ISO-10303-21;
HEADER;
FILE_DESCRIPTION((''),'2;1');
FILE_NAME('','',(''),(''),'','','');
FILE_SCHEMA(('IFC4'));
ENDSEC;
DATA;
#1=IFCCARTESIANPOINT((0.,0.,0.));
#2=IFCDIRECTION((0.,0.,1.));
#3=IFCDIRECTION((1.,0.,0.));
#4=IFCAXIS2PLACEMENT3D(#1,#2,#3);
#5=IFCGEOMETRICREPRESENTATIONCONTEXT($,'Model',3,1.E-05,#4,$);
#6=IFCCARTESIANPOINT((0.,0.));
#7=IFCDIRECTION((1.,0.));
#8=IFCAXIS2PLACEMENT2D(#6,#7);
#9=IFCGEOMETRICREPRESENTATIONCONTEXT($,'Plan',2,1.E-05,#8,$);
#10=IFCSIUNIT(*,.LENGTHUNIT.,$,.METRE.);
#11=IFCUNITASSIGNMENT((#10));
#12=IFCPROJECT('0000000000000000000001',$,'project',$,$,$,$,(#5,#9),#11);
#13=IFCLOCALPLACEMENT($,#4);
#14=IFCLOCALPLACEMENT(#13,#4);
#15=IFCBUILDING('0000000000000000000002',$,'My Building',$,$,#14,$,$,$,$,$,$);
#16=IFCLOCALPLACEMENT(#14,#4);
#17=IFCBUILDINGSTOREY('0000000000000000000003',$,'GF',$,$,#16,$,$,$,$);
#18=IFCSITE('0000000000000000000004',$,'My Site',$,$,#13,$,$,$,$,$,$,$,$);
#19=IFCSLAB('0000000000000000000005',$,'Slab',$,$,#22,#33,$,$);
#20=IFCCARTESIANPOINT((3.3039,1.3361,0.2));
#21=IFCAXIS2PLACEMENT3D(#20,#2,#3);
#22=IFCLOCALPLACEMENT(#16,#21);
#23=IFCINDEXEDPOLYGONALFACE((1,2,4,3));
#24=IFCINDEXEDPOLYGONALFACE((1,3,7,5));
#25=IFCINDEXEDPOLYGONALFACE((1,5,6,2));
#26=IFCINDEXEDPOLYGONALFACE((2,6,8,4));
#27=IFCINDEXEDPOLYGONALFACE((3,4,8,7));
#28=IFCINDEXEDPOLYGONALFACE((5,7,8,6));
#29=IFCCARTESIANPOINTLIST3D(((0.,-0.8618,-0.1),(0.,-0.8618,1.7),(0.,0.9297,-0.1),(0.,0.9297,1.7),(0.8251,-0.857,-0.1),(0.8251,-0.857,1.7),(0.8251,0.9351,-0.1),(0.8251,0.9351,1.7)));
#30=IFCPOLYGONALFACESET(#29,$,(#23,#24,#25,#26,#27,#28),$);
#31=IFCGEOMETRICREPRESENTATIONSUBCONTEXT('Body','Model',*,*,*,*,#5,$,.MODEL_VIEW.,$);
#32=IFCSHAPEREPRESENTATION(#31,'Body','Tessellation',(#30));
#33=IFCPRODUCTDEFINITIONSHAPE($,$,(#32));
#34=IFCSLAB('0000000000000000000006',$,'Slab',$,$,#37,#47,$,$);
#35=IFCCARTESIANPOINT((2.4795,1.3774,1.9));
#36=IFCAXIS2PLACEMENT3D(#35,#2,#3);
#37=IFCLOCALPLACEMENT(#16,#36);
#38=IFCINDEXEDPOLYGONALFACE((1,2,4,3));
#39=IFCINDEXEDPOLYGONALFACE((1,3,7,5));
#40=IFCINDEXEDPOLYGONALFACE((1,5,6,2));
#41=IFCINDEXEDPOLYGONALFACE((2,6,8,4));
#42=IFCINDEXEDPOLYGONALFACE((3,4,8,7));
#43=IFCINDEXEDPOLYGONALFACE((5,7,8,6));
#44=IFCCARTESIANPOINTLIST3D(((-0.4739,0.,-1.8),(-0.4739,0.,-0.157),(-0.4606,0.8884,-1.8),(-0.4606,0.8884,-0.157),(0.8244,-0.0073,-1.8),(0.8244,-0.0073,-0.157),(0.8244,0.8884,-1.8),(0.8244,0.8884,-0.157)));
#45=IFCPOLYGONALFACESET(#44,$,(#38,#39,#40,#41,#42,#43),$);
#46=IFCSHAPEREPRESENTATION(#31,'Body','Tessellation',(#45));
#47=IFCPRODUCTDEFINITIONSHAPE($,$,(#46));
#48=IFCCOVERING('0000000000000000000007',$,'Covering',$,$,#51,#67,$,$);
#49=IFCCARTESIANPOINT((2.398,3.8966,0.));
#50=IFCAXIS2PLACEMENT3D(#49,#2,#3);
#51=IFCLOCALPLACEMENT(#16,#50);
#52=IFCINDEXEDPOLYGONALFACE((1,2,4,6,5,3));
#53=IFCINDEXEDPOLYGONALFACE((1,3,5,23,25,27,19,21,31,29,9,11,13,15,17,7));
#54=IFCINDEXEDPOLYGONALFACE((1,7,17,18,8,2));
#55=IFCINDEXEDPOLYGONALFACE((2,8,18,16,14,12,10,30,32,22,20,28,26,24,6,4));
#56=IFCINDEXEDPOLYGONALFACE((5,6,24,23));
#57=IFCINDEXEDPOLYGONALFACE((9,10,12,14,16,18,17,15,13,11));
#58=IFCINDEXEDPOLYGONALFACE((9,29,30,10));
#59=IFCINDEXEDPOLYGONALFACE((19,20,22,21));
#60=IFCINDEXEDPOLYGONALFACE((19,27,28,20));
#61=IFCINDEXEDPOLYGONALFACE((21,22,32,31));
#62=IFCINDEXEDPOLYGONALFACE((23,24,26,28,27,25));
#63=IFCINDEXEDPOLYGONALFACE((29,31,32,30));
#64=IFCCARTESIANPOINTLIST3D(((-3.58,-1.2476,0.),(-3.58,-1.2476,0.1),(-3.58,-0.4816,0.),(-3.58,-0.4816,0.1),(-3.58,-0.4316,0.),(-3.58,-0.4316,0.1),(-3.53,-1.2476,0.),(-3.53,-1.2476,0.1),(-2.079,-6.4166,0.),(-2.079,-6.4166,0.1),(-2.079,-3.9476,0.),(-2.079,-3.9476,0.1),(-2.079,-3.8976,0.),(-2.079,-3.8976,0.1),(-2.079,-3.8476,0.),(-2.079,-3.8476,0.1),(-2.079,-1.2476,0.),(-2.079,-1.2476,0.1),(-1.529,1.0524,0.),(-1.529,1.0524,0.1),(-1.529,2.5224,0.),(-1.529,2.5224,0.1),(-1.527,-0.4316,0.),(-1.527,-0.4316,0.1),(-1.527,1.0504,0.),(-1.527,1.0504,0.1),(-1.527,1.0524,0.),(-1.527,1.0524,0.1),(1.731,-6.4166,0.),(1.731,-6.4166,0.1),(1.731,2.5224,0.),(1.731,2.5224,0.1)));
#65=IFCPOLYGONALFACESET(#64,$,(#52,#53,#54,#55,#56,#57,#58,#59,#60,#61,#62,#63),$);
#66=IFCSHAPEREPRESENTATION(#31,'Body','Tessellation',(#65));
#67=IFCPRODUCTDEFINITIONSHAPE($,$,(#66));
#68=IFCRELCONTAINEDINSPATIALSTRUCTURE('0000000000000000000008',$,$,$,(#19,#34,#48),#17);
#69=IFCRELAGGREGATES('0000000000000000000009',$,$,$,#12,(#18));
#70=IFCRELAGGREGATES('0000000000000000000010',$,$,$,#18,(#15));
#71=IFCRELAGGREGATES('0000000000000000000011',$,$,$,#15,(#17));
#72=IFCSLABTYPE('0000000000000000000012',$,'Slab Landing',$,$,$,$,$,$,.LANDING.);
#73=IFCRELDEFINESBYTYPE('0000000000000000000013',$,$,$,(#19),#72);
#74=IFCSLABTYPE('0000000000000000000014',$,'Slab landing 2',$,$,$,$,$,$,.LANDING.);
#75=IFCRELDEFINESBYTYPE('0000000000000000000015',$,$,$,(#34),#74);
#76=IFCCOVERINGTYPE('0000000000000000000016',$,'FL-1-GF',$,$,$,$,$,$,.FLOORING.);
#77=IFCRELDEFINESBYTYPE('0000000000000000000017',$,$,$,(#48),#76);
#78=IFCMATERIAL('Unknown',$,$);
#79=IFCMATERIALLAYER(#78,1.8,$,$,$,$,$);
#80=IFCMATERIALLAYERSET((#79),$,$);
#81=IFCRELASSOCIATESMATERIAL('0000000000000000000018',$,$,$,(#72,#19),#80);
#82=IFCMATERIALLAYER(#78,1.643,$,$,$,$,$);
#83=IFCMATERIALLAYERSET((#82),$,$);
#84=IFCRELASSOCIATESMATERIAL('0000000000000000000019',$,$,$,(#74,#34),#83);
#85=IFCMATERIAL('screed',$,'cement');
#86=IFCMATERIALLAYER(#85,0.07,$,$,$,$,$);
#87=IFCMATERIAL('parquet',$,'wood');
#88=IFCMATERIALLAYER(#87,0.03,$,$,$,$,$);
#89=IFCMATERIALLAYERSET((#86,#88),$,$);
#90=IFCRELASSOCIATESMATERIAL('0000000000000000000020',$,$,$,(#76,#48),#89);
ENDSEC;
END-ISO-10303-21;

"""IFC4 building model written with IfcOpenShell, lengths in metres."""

from ifc_helpers import new_model, si_unit, frame, origin_with_axes, origin_2d_with_axis, place, context, subcontext, project, spatial, line, indexed_curve, outline, extrude, material, layer, layer_set, layer_usage, type_object, element, save


model = new_model("IFC4")

# Units and contexts
model_context = context("Model", 3, precision=1e-05, world=origin_with_axes())
plan_context = context("Plan", 2, precision=1e-05, world=origin_2d_with_axis())
body_context_1 = subcontext(model_context, "Body", "Model", "MODEL_VIEW")
ifc_project = project(units=[si_unit("LENGTHUNIT", "METRE")], contexts=[model_context, plan_context])

# Site, building, storey
site_placement = place(None, origin_with_axes())
site = spatial("IfcSite", under=ifc_project, at=site_placement, Name="My Site")
building_placement = place(site_placement, origin_with_axes())
building = spatial("IfcBuilding", under=site, at=building_placement, Name="My Building")
storey_placement = place(building_placement, origin_with_axes())
storey = spatial("IfcBuildingStorey", under=building, at=storey_placement, Name="GF")

# Slabs
ifc_material_1 = material(Name="Unknown")
ifc_layer_1 = layer(ifc_material_1, 1.8)
ifc_layer_set_1 = layer_set([ifc_layer_1])
ifc_layer_usage_1 = layer_usage(ifc_layer_set_1, "AXIS3", "POSITIVE", -0.1)
slab_type_1 = type_object("IfcSlabType", Name="Slab Landing", PredefinedType="LANDING", material=ifc_layer_set_1)
slab_1_placement = place(storey_placement, frame((3.3039, 1.3361, 0.2), z_axis=(0.0, 0.0, 1.0), x_axis=(1.0, 0.0, 0.0)))
element("IfcSlab", 1, at=slab_1_placement, inside=storey, type_object=slab_type_1, material=ifc_layer_usage_1, Name="Slab", context=body_context_1, shape_type="SweptSolid", body=[
    extrude(outline(indexed_curve([(0.8251, 0.9351), (0.8251, -0.857), (0.0, -0.8618), (0.0, 0.9297), (0.8251, 0.9351)])), frame((0.0, 0.0, -0.1), z_axis=(0.0, 0.0, 1.0), x_axis=(1.0, 0.0, 0.0)), (0.0, 0.0, 1.0), 1.8),
])
ifc_layer_2 = layer(ifc_material_1, 1.643)
ifc_layer_set_2 = layer_set([ifc_layer_2])
ifc_layer_usage_2 = layer_usage(ifc_layer_set_2, "AXIS3", "POSITIVE", -1.8)
slab_type_2 = type_object("IfcSlabType", Name="Slab landing 2", PredefinedType="LANDING", material=ifc_layer_set_2)
slab_2_placement = place(storey_placement, frame((2.4795, 1.3774, 1.9), z_axis=(0.0, 0.0, 1.0), x_axis=(1.0, 0.0, 0.0)))
element("IfcSlab", 2, at=slab_2_placement, inside=storey, type_object=slab_type_2, material=ifc_layer_usage_2, Name="Slab", context=body_context_1, shape_type="SweptSolid", body=[
    extrude(outline(indexed_curve([(-0.4606, 0.8884), (0.8244, 0.8884), (0.8244, -0.0073), (-0.4739, 0.0), (-0.4606, 0.8884)])), frame((0.0, 0.0, -1.8), z_axis=(0.0, 0.0, 1.0), x_axis=(1.0, 0.0, 0.0)), (0.0, 0.0, 1.0), 1.643),
])

# Covering
ifc_material_2 = material(Name="screed", Category="cement")
ifc_layer_3 = layer(ifc_material_2, 0.07)
ifc_material_3 = material(Name="parquet", Category="wood")
ifc_layer_4 = layer(ifc_material_3, 0.03)
ifc_layer_set_3 = layer_set([ifc_layer_3, ifc_layer_4])
ifc_layer_usage_3 = layer_usage(ifc_layer_set_3, "AXIS3", "POSITIVE", 0.0)
covering_type = type_object("IfcCoveringType", Name="FL-1-GF", PredefinedType="FLOORING", material=ifc_layer_set_3)
covering_placement = place(storey_placement, frame((2.398, 3.8966, 0.0), z_axis=(0.0, 0.0, 1.0), x_axis=(1.0, 0.0, 0.0)))
element("IfcCovering", 3, at=covering_placement, inside=storey, type_object=covering_type, material=ifc_layer_usage_3, Name="Covering", context=body_context_1, shape_type="SweptSolid", body=[
    extrude(outline(indexed_curve([(1.731, 2.5224), (1.731, -6.4166), (-2.079, -6.4166), (-2.079, -6.4166), (-2.079, -3.9476), (-2.079, -3.8976), (-2.079, -3.8476), (-2.079, -1.2476), (-3.53, -1.2476), (-3.58, -1.2476), (-3.58, -0.4816), (-3.58, -0.4316), (-1.527, -0.4316), (-1.527, 1.0504), (-1.527, 1.0524), (-1.529, 1.0524), (-1.529, 1.0524), (-1.529, 2.5224), (-1.529, 2.5224)], segments=[line(1, 2, 3, 4, 5, 6, 7, 8, 9, 10, 11, 12, 13, 14, 15, 16, 17, 18, 19, 1)])), origin_with_axes(), (0.0, 0.0, 1.0), 0.1),
])

save(model, "model.ifc")
